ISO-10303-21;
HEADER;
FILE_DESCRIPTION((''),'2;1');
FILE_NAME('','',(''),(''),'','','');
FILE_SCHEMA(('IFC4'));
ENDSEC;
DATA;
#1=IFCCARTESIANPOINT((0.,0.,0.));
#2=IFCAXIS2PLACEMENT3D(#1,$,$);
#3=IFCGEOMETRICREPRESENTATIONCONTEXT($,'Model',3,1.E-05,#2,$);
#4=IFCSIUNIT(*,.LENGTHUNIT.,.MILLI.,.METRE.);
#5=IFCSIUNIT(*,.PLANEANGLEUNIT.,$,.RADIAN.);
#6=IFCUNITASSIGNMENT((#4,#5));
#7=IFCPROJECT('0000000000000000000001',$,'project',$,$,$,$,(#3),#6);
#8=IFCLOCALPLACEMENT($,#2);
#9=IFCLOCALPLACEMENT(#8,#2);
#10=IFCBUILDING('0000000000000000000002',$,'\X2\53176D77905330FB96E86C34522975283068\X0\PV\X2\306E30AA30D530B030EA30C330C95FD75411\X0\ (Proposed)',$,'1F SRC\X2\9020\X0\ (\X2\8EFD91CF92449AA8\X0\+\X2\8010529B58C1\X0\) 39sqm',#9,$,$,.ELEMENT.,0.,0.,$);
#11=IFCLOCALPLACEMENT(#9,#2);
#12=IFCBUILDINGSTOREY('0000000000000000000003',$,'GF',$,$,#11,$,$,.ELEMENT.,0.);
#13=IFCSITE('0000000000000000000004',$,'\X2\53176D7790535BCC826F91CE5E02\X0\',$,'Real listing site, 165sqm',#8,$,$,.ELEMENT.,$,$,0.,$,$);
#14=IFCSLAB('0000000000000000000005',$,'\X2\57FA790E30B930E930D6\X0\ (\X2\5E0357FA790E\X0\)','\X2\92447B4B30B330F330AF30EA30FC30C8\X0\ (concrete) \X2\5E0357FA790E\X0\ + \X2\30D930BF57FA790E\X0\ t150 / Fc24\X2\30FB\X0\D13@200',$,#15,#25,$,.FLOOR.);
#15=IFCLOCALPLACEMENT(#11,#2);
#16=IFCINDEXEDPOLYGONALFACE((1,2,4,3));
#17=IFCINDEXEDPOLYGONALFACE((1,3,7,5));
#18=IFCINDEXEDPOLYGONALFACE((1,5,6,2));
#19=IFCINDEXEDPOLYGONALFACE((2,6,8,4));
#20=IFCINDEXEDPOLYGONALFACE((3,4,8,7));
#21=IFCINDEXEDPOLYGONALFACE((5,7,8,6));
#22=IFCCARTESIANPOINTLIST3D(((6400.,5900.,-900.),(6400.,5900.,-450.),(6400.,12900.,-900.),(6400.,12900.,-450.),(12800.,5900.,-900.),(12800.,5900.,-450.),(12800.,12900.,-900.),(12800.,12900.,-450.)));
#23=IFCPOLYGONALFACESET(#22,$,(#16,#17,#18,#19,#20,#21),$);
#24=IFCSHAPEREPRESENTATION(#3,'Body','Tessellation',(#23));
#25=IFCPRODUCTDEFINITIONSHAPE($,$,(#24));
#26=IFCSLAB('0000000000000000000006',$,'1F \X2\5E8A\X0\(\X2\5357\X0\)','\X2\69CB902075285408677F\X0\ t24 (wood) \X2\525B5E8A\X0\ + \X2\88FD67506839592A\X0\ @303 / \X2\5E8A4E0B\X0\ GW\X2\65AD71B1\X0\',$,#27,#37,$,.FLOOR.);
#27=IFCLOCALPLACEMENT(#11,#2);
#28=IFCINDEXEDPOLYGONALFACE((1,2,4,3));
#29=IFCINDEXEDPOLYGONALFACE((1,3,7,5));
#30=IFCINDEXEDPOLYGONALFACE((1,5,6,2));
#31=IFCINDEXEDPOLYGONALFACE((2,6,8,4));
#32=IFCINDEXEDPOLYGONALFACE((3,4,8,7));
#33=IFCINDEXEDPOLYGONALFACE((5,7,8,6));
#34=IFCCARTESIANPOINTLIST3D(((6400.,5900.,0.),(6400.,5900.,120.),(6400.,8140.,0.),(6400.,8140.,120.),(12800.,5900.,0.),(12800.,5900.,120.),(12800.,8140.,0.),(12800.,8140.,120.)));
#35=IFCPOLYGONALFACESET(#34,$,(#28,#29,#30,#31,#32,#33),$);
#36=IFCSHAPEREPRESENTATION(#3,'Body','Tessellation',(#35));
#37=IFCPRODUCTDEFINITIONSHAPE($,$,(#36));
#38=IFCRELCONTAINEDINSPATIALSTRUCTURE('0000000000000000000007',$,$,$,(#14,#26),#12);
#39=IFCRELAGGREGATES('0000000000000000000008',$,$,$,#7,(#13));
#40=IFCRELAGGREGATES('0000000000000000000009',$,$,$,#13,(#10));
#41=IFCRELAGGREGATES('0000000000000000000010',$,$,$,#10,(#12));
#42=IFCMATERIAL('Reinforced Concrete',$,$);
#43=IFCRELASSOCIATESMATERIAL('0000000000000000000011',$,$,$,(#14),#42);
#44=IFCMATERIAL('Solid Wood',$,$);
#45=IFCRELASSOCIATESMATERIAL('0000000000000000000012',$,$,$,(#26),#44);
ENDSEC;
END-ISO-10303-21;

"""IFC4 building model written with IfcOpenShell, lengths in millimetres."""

from ifc_helpers import new_model, si_unit, frame, frame_2d, origin, place, context, project, spatial, rectangle, extrude, material, element, save


model = new_model("IFC4")

# Units and contexts
model_context = context("Model", 3, precision=1e-05, world=origin())
ifc_project = project(units=[si_unit("LENGTHUNIT", "METRE", prefix="MILLI"), si_unit("PLANEANGLEUNIT", "RADIAN")], contexts=[model_context])

# Site, building, storey
site_placement = place(None, origin())
site = spatial("IfcSite", under=ifc_project, at=site_placement, Name="北海道富良野市", ObjectType="Real listing site, 165sqm", CompositionType="ELEMENT", RefElevation=0.0)
building_placement = place(site_placement, origin())
building = spatial("IfcBuilding", under=site, at=building_placement, Name="北海道・雨水利用とPVのオフグリッド志向 (Proposed)", ObjectType="1F SRC造 (軽量鉄骨+耐力壁) 39sqm", CompositionType="ELEMENT", ElevationOfRefHeight=0.0, ElevationOfTerrain=0.0)
storey_placement = place(building_placement, origin())
storey = spatial("IfcBuildingStorey", under=building, at=storey_placement, Name="GF", CompositionType="ELEMENT", Elevation=0.0)

# Shared definitions
ifc_material_1 = material(Name="Solid Wood")

# Slabs
ifc_material_2 = material(Name="Reinforced Concrete")
slab_1_placement = place(storey_placement, frame((3200.0, 2950.0, -450.0)))
element("IfcSlab", 1, at=slab_1_placement, inside=storey, material=ifc_material_2, Name="基礎スラブ (布基礎)", Description="鉄筋コンクリート (concrete) 布基礎 + ベタ基礎 t150 / Fc24・D13@200", PredefinedType="FLOOR", context=model_context, shape_type="SweptSolid", body=[
    extrude(rectangle(XDim=6400.0, YDim=7000.0, at=frame_2d((3200.0, 3500.0))), frame((3200.0, 2950.0, -450.0)), (0.0, 0.0, 1.0), 450.0),
])
slab_2_placement = place(storey_placement, frame((3200.0, 2950.0, 0.0)))
element("IfcSlab", 2, at=slab_2_placement, inside=storey, material=ifc_material_1, Name="1F 床(南)", Description="構造用合板 t24 (wood) 剛床 + 製材根太 @303 / 床下 GW断熱", PredefinedType="FLOOR", context=model_context, shape_type="SweptSolid", body=[
    extrude(rectangle(XDim=6400.0, YDim=2240.0, at=frame_2d((3200.0, 1120.0))), frame((3200.0, 2950.0, 0.0)), (0.0, 0.0, 1.0), 120.0),
])

save(model, "model.ifc")
